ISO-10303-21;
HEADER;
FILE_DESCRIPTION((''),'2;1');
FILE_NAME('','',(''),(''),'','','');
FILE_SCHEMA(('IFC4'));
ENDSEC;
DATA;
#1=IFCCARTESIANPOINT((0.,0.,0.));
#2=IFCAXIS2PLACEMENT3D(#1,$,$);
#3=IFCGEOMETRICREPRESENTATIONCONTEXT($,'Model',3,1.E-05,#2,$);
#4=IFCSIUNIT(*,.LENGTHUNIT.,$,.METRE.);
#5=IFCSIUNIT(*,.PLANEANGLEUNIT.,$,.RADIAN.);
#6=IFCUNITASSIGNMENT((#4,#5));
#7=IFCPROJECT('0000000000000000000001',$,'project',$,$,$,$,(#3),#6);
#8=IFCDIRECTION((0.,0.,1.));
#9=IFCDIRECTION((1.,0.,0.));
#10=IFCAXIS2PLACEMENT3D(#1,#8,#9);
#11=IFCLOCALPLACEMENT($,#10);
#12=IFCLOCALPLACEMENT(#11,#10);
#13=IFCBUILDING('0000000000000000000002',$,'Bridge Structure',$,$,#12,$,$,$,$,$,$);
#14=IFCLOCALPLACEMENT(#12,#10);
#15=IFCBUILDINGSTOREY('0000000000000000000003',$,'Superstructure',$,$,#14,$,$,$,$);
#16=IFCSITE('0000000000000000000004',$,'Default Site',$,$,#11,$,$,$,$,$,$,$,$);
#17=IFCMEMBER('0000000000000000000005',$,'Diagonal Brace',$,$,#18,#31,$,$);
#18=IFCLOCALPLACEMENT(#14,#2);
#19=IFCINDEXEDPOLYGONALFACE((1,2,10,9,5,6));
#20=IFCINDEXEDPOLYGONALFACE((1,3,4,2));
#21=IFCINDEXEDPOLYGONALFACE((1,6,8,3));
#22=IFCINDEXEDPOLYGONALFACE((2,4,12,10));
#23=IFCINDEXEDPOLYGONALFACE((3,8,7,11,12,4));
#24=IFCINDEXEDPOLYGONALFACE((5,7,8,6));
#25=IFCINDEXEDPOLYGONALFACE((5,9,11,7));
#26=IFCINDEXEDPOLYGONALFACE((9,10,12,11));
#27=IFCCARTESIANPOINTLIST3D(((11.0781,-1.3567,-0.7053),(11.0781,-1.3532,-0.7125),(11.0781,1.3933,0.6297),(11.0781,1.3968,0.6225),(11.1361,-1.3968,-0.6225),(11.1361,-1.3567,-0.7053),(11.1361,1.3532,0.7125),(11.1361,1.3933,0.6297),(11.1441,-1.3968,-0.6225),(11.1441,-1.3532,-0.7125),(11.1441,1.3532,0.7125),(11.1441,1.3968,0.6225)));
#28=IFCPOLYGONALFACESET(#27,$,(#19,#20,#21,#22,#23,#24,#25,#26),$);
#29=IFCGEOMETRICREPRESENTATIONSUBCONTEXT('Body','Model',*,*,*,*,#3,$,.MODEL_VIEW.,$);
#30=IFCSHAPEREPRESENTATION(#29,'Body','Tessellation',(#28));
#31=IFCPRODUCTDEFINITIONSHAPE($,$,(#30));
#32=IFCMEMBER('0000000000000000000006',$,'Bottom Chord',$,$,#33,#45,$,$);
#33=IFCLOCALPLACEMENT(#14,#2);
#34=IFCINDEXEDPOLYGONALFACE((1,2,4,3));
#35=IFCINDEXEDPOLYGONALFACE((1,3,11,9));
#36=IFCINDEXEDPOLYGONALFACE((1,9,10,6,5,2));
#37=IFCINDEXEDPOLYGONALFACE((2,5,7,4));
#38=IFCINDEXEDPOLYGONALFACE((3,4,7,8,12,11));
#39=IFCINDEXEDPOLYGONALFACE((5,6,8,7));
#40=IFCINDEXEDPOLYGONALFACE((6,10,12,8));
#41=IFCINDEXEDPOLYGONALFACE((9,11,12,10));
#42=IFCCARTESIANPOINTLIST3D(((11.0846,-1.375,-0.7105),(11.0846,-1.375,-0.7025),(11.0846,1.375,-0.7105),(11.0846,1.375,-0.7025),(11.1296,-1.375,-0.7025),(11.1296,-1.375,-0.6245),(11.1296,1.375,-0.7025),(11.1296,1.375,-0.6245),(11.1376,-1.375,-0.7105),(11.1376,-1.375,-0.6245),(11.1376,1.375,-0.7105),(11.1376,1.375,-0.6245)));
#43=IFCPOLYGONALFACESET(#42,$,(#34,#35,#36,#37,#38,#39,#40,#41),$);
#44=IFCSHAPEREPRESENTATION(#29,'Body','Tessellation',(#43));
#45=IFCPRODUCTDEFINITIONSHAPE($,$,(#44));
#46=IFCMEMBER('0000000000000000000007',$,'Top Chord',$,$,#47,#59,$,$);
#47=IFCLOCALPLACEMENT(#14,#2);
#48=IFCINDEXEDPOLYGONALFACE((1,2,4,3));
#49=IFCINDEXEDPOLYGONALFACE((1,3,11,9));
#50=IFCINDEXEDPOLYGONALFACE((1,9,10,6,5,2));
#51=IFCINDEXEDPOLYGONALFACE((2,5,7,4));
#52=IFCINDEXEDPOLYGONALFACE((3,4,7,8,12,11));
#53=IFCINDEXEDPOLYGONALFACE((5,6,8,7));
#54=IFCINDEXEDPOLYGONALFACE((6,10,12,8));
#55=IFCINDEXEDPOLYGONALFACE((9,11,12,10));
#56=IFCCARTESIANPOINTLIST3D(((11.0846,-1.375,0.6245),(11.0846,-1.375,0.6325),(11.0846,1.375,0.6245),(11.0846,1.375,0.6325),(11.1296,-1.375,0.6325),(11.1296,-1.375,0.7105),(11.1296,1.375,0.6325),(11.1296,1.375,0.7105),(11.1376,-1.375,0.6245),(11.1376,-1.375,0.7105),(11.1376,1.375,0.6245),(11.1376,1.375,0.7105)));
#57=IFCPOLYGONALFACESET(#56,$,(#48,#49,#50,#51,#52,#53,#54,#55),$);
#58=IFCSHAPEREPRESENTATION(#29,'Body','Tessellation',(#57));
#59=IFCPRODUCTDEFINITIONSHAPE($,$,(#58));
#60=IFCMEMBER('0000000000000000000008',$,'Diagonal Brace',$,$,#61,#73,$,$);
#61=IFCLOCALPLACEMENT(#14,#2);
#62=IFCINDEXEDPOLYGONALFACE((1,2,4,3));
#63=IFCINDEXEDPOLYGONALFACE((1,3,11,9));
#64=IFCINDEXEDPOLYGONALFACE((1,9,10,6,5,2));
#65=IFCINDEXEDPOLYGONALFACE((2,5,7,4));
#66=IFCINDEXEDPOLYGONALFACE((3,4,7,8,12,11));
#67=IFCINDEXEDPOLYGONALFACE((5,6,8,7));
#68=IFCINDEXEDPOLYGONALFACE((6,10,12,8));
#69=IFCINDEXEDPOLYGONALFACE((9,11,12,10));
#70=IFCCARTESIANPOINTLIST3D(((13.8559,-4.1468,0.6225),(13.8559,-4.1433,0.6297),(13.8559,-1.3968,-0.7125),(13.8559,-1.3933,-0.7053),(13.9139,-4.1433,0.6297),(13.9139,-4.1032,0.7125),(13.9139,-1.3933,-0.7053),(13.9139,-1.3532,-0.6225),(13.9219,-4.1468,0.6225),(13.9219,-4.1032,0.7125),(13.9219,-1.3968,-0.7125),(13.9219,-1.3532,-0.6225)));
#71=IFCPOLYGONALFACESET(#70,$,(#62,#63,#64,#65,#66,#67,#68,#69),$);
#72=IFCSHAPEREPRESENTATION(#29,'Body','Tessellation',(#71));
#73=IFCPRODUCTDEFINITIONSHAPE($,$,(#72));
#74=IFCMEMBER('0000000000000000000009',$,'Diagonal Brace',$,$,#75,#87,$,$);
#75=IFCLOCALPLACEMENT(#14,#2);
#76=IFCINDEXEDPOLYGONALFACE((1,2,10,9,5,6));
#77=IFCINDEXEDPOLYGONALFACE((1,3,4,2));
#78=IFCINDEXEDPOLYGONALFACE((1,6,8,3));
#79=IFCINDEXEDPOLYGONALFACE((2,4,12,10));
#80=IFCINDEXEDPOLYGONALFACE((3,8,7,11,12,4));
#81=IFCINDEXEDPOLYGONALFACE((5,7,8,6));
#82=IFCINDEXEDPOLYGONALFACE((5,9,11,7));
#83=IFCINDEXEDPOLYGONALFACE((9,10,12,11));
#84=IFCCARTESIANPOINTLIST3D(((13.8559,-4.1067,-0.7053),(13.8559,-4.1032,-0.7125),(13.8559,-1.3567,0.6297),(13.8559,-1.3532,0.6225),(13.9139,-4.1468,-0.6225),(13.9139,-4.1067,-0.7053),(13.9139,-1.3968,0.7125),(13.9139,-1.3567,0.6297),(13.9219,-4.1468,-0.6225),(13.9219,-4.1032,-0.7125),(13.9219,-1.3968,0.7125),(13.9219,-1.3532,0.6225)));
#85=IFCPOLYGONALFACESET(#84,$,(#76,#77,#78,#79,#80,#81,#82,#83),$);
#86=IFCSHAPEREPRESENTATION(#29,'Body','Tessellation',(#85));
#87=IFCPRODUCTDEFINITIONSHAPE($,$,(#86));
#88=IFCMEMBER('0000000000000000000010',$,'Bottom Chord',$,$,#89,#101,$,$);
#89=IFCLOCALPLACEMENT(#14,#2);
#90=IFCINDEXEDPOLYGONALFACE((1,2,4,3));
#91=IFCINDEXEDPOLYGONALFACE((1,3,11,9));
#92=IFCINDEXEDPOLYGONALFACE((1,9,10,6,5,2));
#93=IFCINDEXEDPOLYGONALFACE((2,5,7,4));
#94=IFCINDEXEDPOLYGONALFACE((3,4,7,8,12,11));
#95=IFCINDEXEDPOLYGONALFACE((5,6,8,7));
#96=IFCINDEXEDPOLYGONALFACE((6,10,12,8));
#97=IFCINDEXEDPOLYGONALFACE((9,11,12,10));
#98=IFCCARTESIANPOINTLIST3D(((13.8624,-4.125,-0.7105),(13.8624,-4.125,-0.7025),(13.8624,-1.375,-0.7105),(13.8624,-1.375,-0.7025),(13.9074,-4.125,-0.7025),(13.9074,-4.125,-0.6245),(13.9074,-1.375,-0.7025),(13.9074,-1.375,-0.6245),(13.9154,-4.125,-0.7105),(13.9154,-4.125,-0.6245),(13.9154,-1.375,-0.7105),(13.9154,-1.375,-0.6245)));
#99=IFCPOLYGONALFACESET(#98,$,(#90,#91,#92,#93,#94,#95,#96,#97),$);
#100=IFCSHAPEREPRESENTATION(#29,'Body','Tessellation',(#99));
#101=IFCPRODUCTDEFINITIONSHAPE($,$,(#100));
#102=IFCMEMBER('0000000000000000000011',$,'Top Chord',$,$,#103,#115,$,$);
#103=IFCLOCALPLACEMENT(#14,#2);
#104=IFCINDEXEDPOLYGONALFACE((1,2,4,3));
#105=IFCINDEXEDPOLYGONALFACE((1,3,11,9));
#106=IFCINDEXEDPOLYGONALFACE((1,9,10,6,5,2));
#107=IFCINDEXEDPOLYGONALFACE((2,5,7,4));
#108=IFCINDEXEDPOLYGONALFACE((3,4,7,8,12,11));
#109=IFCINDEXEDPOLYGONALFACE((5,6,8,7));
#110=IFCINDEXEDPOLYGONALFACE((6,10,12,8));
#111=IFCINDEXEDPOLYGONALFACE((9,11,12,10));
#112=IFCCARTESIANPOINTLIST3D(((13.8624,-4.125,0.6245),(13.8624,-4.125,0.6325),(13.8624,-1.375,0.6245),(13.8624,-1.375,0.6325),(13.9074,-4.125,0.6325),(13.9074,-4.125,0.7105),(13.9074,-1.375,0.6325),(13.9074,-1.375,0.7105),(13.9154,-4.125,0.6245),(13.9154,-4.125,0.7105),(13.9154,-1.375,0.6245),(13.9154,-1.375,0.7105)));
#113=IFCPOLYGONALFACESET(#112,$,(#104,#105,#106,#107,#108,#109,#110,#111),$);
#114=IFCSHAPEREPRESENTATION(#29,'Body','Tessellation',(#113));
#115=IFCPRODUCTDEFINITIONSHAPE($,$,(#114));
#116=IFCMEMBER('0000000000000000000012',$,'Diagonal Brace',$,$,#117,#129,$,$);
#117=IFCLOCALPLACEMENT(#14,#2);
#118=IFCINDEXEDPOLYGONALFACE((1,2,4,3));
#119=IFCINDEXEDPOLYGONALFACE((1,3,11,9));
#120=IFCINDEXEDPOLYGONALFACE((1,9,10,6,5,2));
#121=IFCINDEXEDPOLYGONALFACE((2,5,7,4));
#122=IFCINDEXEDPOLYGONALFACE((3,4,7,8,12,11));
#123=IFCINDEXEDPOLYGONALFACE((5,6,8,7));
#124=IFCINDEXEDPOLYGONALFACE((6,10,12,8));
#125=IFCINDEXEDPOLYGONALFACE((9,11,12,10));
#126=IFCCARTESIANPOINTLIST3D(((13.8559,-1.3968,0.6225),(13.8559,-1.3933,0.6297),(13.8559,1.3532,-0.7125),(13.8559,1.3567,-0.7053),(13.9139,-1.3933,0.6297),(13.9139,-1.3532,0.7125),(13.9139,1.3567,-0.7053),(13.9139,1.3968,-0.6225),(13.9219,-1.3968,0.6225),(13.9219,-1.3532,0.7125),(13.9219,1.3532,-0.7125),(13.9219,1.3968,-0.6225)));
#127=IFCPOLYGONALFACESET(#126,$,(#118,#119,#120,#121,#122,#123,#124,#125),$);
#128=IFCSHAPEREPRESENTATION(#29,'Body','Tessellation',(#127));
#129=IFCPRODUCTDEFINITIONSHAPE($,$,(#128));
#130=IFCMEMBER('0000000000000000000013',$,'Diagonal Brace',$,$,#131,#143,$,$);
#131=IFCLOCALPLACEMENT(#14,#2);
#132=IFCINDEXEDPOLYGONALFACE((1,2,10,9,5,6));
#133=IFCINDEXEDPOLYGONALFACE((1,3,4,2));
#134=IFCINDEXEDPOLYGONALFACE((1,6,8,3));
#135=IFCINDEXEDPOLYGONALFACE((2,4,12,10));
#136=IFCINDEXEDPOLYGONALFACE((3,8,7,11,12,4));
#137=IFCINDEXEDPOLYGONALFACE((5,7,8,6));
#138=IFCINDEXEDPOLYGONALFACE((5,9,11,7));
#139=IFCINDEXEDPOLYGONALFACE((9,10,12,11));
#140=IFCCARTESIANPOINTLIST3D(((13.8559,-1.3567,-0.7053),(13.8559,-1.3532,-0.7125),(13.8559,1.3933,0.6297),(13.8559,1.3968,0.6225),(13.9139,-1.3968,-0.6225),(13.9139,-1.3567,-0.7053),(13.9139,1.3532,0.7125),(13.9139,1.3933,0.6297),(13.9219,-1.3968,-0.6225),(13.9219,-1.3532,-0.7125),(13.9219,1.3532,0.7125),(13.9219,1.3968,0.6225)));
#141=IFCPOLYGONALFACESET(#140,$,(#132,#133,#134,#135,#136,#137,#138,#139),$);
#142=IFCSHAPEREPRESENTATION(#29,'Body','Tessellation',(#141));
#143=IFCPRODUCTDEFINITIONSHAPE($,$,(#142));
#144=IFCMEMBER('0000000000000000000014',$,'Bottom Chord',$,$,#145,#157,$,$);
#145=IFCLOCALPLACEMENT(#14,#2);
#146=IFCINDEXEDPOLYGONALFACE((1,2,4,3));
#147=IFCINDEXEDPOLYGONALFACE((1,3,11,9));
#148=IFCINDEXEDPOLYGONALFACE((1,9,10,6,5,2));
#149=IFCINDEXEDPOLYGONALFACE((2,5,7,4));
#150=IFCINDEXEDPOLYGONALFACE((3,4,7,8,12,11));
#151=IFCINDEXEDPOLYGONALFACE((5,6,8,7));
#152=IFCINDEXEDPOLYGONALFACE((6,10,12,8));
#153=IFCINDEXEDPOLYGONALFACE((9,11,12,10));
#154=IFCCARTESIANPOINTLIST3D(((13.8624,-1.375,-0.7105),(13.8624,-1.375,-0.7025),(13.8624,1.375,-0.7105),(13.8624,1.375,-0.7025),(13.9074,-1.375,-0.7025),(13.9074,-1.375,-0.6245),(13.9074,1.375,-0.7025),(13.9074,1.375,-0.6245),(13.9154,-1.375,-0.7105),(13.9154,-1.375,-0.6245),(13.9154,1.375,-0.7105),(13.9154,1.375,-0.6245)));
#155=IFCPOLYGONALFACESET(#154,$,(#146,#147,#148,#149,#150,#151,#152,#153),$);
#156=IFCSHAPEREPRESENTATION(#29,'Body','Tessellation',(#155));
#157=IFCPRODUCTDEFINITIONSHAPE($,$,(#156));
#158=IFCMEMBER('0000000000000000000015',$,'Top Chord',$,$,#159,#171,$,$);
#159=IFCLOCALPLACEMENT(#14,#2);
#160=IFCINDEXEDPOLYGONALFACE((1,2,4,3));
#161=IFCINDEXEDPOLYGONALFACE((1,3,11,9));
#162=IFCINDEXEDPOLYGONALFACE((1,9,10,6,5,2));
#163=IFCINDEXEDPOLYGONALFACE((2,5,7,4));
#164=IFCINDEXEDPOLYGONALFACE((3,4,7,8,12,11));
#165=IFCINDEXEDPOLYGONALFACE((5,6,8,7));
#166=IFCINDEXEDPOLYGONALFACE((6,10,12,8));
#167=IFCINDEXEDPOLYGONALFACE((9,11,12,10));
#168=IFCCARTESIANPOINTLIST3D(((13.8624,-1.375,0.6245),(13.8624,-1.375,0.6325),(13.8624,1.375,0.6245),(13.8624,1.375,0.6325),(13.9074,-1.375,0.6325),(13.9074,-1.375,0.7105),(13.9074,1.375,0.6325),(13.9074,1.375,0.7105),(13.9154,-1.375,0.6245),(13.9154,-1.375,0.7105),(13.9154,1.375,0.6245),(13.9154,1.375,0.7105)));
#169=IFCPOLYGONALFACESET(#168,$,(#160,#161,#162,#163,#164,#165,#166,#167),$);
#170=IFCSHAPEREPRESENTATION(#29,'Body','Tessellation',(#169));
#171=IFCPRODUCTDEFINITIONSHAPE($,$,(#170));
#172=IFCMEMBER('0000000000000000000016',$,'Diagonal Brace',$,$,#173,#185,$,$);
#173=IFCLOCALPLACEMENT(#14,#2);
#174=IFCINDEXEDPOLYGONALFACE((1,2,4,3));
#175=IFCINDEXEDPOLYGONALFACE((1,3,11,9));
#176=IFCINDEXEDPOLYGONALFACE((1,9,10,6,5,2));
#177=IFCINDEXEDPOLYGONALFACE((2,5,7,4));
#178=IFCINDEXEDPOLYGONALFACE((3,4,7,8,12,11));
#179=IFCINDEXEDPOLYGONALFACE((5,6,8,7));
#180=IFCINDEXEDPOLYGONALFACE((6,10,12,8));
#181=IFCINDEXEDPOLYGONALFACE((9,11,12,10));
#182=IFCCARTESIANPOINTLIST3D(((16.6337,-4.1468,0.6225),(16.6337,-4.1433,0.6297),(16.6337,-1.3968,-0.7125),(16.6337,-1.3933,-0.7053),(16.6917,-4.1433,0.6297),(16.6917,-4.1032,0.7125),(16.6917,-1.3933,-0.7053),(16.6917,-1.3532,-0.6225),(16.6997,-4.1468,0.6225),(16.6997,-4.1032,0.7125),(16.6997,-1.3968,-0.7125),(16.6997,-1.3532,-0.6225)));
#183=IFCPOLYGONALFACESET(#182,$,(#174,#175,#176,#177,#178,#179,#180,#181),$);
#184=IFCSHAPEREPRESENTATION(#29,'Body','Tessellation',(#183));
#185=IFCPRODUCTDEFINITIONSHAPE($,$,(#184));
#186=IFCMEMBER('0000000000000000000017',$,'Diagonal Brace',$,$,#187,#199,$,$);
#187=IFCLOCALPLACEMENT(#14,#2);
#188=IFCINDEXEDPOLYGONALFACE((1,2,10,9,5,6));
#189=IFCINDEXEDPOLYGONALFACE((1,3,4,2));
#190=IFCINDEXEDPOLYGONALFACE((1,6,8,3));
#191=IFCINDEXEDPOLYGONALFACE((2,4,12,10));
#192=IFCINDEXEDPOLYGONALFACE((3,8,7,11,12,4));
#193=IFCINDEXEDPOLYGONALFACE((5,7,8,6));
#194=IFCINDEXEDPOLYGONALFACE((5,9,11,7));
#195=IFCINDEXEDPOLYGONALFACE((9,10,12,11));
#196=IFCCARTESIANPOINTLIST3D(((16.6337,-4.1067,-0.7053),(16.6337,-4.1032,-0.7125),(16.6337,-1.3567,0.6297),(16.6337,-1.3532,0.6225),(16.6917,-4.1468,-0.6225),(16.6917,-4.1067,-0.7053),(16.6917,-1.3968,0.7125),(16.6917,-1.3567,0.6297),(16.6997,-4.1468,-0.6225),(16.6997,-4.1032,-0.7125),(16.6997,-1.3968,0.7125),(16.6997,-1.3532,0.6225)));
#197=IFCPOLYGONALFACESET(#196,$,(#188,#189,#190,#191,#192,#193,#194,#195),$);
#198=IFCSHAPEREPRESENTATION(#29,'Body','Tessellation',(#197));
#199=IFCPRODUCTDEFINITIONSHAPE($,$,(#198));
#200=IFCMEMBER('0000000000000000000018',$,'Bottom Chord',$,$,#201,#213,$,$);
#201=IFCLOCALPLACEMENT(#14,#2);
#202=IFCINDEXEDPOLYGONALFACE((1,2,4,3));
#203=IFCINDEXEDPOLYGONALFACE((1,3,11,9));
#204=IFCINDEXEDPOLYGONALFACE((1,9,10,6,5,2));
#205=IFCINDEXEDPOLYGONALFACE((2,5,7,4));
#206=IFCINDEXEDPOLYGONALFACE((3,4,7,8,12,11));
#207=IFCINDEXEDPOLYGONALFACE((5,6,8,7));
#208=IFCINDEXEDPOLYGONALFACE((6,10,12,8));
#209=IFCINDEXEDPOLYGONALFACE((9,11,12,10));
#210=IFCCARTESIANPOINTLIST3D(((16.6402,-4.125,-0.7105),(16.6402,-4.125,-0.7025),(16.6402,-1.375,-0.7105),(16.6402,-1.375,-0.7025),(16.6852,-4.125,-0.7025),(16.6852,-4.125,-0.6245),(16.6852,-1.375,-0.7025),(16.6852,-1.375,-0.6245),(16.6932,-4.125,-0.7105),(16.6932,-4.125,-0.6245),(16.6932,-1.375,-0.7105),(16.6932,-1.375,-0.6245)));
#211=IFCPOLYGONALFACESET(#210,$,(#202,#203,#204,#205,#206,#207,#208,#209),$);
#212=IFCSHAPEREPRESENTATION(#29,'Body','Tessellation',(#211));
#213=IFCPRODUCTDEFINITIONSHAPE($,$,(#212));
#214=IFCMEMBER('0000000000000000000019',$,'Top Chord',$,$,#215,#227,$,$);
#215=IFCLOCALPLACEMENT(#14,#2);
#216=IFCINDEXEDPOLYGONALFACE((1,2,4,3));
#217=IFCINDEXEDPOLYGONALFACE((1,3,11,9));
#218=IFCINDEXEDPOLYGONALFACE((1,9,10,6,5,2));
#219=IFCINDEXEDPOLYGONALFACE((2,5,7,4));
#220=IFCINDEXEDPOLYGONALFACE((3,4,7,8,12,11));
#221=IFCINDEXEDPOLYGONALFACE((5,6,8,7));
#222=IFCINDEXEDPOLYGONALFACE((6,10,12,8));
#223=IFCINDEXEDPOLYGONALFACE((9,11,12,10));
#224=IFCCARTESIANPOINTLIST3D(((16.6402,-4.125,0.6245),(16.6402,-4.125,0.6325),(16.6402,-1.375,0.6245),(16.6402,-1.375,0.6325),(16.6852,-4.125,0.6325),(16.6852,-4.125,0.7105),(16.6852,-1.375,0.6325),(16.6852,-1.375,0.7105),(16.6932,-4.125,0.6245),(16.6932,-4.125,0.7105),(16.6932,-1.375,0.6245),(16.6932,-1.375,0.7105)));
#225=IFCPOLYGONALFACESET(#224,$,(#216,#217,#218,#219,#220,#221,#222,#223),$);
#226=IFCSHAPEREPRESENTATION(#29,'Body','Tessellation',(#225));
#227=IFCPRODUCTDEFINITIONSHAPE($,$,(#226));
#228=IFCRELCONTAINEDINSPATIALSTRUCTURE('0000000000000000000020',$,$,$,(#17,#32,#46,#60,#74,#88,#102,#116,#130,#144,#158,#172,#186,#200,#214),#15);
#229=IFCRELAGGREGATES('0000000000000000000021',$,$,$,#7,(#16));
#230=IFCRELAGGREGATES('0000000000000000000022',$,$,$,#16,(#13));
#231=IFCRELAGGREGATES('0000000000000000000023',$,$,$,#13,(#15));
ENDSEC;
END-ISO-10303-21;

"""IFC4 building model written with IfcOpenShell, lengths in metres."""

from ifc_helpers import new_model, si_unit, frame, origin, origin_with_axes, origin_2d_with_axis, place, context, subcontext, project, spatial, l_section, extrude, element, save


model = new_model("IFC4")

# Units and contexts
model_context = context("Model", 3, precision=1e-05, world=origin())
body_context = subcontext(model_context, "Body", "Model", "MODEL_VIEW")
ifc_project = project(units=[si_unit("LENGTHUNIT", "METRE"), si_unit("PLANEANGLEUNIT", "RADIAN")], contexts=[model_context])

# Site, building, storey
site_placement = place(None, origin_with_axes())
site = spatial("IfcSite", under=ifc_project, at=site_placement, Name="Default Site")
building_placement = place(site_placement, origin_with_axes())
building = spatial("IfcBuilding", under=site, at=building_placement, Name="Bridge Structure")
storey_placement = place(building_placement, origin_with_axes())
storey = spatial("IfcBuildingStorey", under=building, at=storey_placement, Name="Superstructure")

# Members
member_placement = place(storey_placement, frame((11.1111, -1.375, -0.6675), z_axis=(0.0, 0.8996, 0.436715), x_axis=(-1.0, 0.0, 0.0)))
element("IfcMember", 1, at=member_placement, inside=storey, Name="Diagonal Brace", context=body_context, shape_type="SweptSolid", body=[
    extrude(l_section(Depth=0.1, Width=0.066, Thickness=0.008, at=origin_2d_with_axis()), origin_with_axes(), (0.0, 0.0, 1.0), 3.0569),
])
for number, where, z_axis, x_axis, name in (
    (2, (11.1111, -1.375, -0.6675), (0.0, 1.0, 0.0), (-1.0, 0.0, 0.0), "Bottom Chord"),
    (3, (11.1111, -1.375, 0.6675), (0.0, 1.0, 0.0), (-1.0, 0.0, 0.0), "Top Chord"),
):
    element("IfcMember", number, at=place(storey_placement, frame(where, z_axis=z_axis, x_axis=x_axis)), inside=storey, Name=name, context=body_context, shape_type="SweptSolid", body=[
        extrude(l_section(Depth=0.086, Width=0.053, Thickness=0.008, at=origin_2d_with_axis()), origin_with_axes(), (0.0, 0.0, 1.0), 2.75),
    ])
for number, where, z_axis, x_axis, name in (
    (4, (13.8889, -4.125, 0.6675), (0.0, 0.8996, -0.436715), (-1.0, 0.0, 0.0), "Diagonal Brace"),
    (5, (13.8889, -4.125, -0.6675), (0.0, 0.8996, 0.436715), (-1.0, 0.0, 0.0), "Diagonal Brace"),
):
    element("IfcMember", number, at=place(storey_placement, frame(where, z_axis=z_axis, x_axis=x_axis)), inside=storey, Name=name, context=body_context, shape_type="SweptSolid", body=[
        extrude(l_section(Depth=0.1, Width=0.066, Thickness=0.008, at=origin_2d_with_axis()), origin_with_axes(), (0.0, 0.0, 1.0), 3.0569),
    ])
for number, where, z_axis, x_axis, name in (
    (6, (13.8889, -4.125, -0.6675), (0.0, 1.0, 0.0), (-1.0, 0.0, 0.0), "Bottom Chord"),
    (7, (13.8889, -4.125, 0.6675), (0.0, 1.0, 0.0), (-1.0, 0.0, 0.0), "Top Chord"),
):
    element("IfcMember", number, at=place(storey_placement, frame(where, z_axis=z_axis, x_axis=x_axis)), inside=storey, Name=name, context=body_context, shape_type="SweptSolid", body=[
        extrude(l_section(Depth=0.086, Width=0.053, Thickness=0.008, at=origin_2d_with_axis()), origin_with_axes(), (0.0, 0.0, 1.0), 2.75),
    ])
for number, where, z_axis, x_axis, name in (
    (8, (13.8889, -1.375, 0.6675), (0.0, 0.8996, -0.436715), (-1.0, 0.0, 0.0), "Diagonal Brace"),
    (9, (13.8889, -1.375, -0.6675), (0.0, 0.8996, 0.436715), (-1.0, 0.0, 0.0), "Diagonal Brace"),
):
    element("IfcMember", number, at=place(storey_placement, frame(where, z_axis=z_axis, x_axis=x_axis)), inside=storey, Name=name, context=body_context, shape_type="SweptSolid", body=[
        extrude(l_section(Depth=0.1, Width=0.066, Thickness=0.008, at=origin_2d_with_axis()), origin_with_axes(), (0.0, 0.0, 1.0), 3.0569),
    ])
for number, where, z_axis, x_axis, name in (
    (10, (13.8889, -1.375, -0.6675), (0.0, 1.0, 0.0), (-1.0, 0.0, 0.0), "Bottom Chord"),
    (11, (13.8889, -1.375, 0.6675), (0.0, 1.0, 0.0), (-1.0, 0.0, 0.0), "Top Chord"),
):
    element("IfcMember", number, at=place(storey_placement, frame(where, z_axis=z_axis, x_axis=x_axis)), inside=storey, Name=name, context=body_context, shape_type="SweptSolid", body=[
        extrude(l_section(Depth=0.086, Width=0.053, Thickness=0.008, at=origin_2d_with_axis()), origin_with_axes(), (0.0, 0.0, 1.0), 2.75),
    ])
for number, where, z_axis, x_axis, name in (
    (12, (16.6667, -4.125, 0.6675), (0.0, 0.8996, -0.436715), (-1.0, 0.0, 0.0), "Diagonal Brace"),
    (13, (16.6667, -4.125, -0.6675), (0.0, 0.8996, 0.436715), (-1.0, 0.0, 0.0), "Diagonal Brace"),
):
    element("IfcMember", number, at=place(storey_placement, frame(where, z_axis=z_axis, x_axis=x_axis)), inside=storey, Name=name, context=body_context, shape_type="SweptSolid", body=[
        extrude(l_section(Depth=0.1, Width=0.066, Thickness=0.008, at=origin_2d_with_axis()), origin_with_axes(), (0.0, 0.0, 1.0), 3.0569),
    ])
for number, where, z_axis, x_axis, name in (
    (14, (16.6667, -4.125, -0.6675), (0.0, 1.0, 0.0), (-1.0, 0.0, 0.0), "Bottom Chord"),
    (15, (16.6667, -4.125, 0.6675), (0.0, 1.0, 0.0), (-1.0, 0.0, 0.0), "Top Chord"),
):
    element("IfcMember", number, at=place(storey_placement, frame(where, z_axis=z_axis, x_axis=x_axis)), inside=storey, Name=name, context=body_context, shape_type="SweptSolid", body=[
        extrude(l_section(Depth=0.086, Width=0.053, Thickness=0.008, at=origin_2d_with_axis()), origin_with_axes(), (0.0, 0.0, 1.0), 2.75),
    ])

save(model, "model.ifc")
